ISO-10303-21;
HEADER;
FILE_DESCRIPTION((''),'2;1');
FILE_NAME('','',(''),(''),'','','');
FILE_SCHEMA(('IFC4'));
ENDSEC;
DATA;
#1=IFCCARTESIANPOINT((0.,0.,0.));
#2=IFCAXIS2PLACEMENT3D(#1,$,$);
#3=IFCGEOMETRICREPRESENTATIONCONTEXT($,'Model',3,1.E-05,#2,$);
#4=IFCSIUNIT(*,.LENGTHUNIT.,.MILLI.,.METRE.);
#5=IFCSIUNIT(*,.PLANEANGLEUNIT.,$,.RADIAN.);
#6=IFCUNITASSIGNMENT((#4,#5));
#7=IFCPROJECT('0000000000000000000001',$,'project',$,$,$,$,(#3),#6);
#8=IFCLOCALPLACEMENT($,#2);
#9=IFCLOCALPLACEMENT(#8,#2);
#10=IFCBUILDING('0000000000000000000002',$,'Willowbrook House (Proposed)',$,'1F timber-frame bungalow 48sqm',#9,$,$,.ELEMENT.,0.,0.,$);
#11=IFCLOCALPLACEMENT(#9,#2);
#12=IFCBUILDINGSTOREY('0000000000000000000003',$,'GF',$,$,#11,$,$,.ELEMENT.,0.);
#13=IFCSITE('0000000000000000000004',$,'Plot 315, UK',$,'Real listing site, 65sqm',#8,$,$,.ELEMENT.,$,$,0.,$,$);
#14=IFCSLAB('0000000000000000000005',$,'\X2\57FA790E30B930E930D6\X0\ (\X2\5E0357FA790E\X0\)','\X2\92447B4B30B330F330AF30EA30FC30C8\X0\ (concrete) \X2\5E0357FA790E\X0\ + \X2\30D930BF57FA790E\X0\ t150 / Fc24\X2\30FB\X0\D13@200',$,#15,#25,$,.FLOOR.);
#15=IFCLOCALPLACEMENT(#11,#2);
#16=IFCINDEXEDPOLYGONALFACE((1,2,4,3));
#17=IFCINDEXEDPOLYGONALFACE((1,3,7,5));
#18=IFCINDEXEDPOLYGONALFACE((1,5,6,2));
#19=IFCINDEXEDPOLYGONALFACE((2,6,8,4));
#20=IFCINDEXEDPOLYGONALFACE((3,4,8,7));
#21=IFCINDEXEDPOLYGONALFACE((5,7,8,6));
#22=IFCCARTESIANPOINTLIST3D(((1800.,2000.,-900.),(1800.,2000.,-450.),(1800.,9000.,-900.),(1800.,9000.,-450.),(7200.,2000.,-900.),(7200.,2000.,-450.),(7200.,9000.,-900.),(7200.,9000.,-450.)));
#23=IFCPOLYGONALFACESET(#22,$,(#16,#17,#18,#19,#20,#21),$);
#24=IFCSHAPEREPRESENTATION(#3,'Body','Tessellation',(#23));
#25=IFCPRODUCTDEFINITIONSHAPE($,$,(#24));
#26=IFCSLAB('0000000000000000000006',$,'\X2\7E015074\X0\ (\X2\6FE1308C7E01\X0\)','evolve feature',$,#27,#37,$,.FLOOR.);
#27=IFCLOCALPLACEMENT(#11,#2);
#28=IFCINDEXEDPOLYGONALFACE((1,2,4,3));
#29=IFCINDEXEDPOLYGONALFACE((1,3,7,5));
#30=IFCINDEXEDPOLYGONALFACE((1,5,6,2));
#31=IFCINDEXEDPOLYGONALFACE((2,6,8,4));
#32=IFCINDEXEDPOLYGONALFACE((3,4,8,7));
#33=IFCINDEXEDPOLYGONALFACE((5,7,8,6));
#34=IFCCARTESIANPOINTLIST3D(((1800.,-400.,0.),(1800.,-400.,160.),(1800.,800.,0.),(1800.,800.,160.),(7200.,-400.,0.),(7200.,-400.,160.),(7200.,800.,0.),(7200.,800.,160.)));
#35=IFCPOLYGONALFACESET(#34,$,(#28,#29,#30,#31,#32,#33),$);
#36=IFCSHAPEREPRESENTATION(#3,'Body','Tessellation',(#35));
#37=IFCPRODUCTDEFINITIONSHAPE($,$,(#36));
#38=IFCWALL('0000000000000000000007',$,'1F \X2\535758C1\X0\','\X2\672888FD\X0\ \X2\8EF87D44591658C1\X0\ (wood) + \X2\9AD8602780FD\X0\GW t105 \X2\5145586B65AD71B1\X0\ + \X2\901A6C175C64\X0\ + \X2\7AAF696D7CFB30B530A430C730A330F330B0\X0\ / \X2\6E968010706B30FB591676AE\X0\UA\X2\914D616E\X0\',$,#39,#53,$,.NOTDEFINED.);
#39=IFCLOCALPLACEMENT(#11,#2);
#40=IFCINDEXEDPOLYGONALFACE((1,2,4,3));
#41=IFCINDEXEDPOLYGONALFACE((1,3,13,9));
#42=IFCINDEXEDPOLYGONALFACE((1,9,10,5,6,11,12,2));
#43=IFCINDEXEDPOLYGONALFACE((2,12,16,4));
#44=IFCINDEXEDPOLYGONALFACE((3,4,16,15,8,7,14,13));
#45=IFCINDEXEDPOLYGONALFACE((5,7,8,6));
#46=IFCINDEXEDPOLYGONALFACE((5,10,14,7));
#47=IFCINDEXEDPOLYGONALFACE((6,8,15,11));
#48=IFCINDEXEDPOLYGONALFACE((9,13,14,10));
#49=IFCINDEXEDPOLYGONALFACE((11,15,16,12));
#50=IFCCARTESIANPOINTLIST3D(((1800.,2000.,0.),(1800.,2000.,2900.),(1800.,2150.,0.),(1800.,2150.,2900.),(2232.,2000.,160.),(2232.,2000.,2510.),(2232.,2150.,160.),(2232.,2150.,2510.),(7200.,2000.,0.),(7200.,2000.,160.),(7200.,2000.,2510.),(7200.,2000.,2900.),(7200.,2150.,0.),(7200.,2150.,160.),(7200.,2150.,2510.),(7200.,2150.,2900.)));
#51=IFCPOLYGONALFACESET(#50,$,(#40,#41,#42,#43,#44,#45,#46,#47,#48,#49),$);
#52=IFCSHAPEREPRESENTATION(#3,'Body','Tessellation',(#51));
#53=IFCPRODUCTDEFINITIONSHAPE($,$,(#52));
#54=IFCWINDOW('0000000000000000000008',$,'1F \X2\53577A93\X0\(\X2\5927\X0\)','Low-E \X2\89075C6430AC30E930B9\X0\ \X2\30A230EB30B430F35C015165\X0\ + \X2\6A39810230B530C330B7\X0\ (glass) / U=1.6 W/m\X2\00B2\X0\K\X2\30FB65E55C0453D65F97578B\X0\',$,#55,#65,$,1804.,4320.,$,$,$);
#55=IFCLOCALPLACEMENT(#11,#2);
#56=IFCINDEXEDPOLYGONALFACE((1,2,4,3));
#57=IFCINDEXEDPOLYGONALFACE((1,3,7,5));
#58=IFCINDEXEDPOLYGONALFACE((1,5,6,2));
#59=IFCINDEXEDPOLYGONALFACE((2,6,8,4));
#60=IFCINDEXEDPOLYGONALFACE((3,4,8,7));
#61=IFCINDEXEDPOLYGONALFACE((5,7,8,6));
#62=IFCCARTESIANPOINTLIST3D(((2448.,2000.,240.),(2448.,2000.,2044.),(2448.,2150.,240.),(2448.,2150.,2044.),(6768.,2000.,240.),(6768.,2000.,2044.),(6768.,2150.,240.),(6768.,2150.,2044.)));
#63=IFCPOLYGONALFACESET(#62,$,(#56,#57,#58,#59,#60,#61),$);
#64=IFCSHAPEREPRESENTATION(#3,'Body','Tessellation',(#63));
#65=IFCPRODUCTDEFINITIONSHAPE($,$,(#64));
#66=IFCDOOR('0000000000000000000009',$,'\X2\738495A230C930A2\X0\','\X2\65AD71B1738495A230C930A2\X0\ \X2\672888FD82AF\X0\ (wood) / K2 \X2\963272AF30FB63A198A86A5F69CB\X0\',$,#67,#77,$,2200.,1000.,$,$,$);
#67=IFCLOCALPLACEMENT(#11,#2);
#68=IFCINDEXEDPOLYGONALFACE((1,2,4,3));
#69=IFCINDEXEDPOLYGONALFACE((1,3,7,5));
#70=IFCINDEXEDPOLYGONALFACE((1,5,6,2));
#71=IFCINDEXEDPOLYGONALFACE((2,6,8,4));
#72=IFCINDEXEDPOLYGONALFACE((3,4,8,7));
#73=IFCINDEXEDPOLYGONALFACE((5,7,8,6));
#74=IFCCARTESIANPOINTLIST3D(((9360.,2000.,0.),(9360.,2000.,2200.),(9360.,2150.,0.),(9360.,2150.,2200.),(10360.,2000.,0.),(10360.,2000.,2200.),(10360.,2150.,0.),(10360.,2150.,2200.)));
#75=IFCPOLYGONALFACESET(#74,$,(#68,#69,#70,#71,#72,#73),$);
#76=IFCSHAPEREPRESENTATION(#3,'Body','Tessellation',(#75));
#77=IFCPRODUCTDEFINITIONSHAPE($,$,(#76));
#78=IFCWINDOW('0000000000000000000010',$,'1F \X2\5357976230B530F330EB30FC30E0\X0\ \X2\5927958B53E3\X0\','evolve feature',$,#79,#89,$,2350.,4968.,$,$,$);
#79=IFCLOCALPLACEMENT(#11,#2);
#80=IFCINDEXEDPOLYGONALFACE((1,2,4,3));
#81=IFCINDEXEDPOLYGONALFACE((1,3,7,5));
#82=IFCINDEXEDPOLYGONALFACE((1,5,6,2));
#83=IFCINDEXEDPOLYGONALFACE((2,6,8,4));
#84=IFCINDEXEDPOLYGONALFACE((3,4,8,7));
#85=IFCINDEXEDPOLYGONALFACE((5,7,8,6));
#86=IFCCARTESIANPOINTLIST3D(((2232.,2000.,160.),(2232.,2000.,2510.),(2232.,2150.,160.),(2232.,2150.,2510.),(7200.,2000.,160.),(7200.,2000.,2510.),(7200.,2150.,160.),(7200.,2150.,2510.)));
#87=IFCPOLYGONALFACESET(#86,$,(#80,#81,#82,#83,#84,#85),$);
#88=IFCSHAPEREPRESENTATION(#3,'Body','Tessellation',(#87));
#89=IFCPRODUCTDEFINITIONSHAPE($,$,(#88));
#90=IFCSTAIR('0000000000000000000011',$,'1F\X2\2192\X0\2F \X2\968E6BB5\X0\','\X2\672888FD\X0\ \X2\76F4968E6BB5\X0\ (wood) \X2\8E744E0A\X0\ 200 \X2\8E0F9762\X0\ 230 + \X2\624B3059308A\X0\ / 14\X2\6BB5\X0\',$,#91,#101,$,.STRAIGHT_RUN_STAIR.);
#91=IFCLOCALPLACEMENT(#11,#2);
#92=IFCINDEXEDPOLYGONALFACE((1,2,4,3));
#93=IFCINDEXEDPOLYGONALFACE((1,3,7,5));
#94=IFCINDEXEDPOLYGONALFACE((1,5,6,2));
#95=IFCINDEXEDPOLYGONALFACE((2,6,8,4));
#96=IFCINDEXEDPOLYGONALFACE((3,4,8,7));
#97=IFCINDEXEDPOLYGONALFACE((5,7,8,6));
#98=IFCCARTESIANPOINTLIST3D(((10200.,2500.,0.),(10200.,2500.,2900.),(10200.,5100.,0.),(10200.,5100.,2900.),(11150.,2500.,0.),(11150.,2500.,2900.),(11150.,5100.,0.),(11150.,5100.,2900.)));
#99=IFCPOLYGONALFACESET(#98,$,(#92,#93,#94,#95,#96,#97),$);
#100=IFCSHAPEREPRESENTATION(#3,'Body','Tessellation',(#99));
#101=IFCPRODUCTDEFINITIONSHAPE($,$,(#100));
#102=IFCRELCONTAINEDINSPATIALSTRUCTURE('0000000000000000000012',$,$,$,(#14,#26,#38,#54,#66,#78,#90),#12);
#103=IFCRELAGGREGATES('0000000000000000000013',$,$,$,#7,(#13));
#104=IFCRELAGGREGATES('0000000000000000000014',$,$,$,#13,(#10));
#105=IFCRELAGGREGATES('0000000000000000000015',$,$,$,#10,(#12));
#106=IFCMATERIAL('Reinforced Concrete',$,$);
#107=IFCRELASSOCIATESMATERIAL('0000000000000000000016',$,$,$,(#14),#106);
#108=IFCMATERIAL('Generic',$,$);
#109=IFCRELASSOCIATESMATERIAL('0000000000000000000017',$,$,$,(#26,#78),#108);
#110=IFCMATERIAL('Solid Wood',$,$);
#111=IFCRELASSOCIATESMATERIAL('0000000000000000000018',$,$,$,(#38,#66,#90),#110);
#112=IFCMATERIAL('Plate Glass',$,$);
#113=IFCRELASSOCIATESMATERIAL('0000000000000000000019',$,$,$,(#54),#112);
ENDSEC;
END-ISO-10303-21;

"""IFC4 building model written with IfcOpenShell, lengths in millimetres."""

from ifc_helpers import new_model, si_unit, frame, frame_2d, origin, place, context, project, spatial, rectangle, extrude, material, element, fill, save


model = new_model("IFC4")

# Units and contexts
model_context = context("Model", 3, precision=1e-05, world=origin())
ifc_project = project(units=[si_unit("LENGTHUNIT", "METRE", prefix="MILLI"), si_unit("PLANEANGLEUNIT", "RADIAN")], contexts=[model_context])

# Site, building, storey
site_placement = place(None, origin())
site = spatial("IfcSite", under=ifc_project, at=site_placement, Name="Plot 315, UK", ObjectType="Real listing site, 65sqm", CompositionType="ELEMENT", RefElevation=0.0)
building_placement = place(site_placement, origin())
building = spatial("IfcBuilding", under=site, at=building_placement, Name="Willowbrook House (Proposed)", ObjectType="1F timber-frame bungalow 48sqm", CompositionType="ELEMENT", ElevationOfRefHeight=0.0, ElevationOfTerrain=0.0)
storey_placement = place(building_placement, origin())
storey = spatial("IfcBuildingStorey", under=building, at=storey_placement, Name="GF", CompositionType="ELEMENT", Elevation=0.0)

# Slabs
ifc_material_1 = material(Name="Reinforced Concrete")
slab_1_placement = place(storey_placement, frame((900.0, 1000.0, -450.0)))
element("IfcSlab", 1, at=slab_1_placement, inside=storey, material=ifc_material_1, Name="基礎スラブ (布基礎)", Description="鉄筋コンクリート (concrete) 布基礎 + ベタ基礎 t150 / Fc24・D13@200", PredefinedType="FLOOR", context=model_context, shape_type="SweptSolid", body=[
    extrude(rectangle(XDim=5400.0, YDim=7000.0, at=frame_2d((2700.0, 3500.0))), frame((900.0, 1000.0, -450.0)), (0.0, 0.0, 1.0), 450.0),
])
ifc_material_2 = material(Name="Solid Wood")
ifc_material_3 = material(Name="Generic")
slab_2_placement = place(storey_placement, frame((900.0, -200.0, 0.0)))
element("IfcSlab", 2, at=slab_2_placement, inside=storey, material=ifc_material_3, Name="縁側 (濡れ縁)", Description="evolve feature", PredefinedType="FLOOR", context=model_context, shape_type="SweptSolid", body=[
    extrude(rectangle(XDim=5400.0, YDim=1200.0, at=frame_2d((2700.0, 600.0))), frame((900.0, -200.0, 0.0)), (0.0, 0.0, 1.0), 160.0),
])

# Wall, openings, windows, door
wall_1_placement = place(storey_placement, frame((900.0, 1000.0, 0.0)))
wall_1 = element("IfcWall", 3, at=wall_1_placement, inside=storey, material=ifc_material_2, Name="1F 南壁", Description="木製 軸組外壁 (wood) + 高性能GW t105 充填断熱 + 通気層 + 窯業系サイディング / 準耐火・外皮UA配慮", PredefinedType="NOTDEFINED", context=model_context, shape_type="SweptSolid", body=[
    extrude(rectangle(XDim=5400.0, YDim=150.0, at=frame_2d((2700.0, 75.0))), frame((900.0, 1000.0, 0.0)), (0.0, 0.0, 1.0), 2900.0),
])
opening_1_placement = place(storey_placement, frame((1224.0, 1000.0, 120.0)))
opening_1 = element("IfcOpeningElement", 4, at=opening_1_placement, cuts=wall_1, PredefinedType="NOTDEFINED", context=model_context, shape_type="SweptSolid", body=[
    extrude(rectangle(XDim=4320.0, YDim=150.0, at=frame_2d((2160.0, 75.0))), frame((1224.0, 1000.0, 120.0)), (0.0, 0.0, 1.0), 1804.0),
])
opening_2_placement = place(storey_placement, frame((4680.0, 1000.0, 0.0)))
opening_2 = element("IfcOpeningElement", 5, at=opening_2_placement, cuts=wall_1, PredefinedType="NOTDEFINED", context=model_context, shape_type="SweptSolid", body=[
    extrude(rectangle(XDim=1000.0, YDim=150.0, at=frame_2d((500.0, 75.0))), frame((4680.0, 1000.0, 0.0)), (0.0, 0.0, 1.0), 2200.0),
])
opening_3_placement = place(storey_placement, frame((1116.0, 1000.0, 80.0)))
opening_3 = element("IfcOpeningElement", 6, at=opening_3_placement, cuts=wall_1, PredefinedType="NOTDEFINED", context=model_context, shape_type="SweptSolid", body=[
    extrude(rectangle(XDim=4968.0, YDim=150.0, at=frame_2d((2484.0, 75.0))), frame((1116.0, 1000.0, 80.0)), (0.0, 0.0, 1.0), 2350.0),
])
ifc_material_4 = material(Name="Plate Glass")
window_1_placement = place(storey_placement, frame((1224.0, 1000.0, 120.0)))
window_1 = element("IfcWindow", 7, at=window_1_placement, inside=storey, material=ifc_material_4, Name="1F 南窓(大)", Description="Low-E 複層ガラス アルゴン封入 + 樹脂サッシ (glass) / U=1.6 W/m²K・日射取得型", OverallHeight=1804.0, OverallWidth=4320.0, context=model_context, shape_type="SweptSolid", body=[
    extrude(rectangle(XDim=4320.0, YDim=150.0, at=frame_2d((2160.0, 75.0))), frame((1224.0, 1000.0, 120.0)), (0.0, 0.0, 1.0), 1804.0),
])
fill(opening_1, window_1)
door_placement = place(storey_placement, frame((4680.0, 1000.0, 0.0)))
door = element("IfcDoor", 8, at=door_placement, inside=storey, material=ifc_material_2, Name="玄関ドア", Description="断熱玄関ドア 木製芯 (wood) / K2 防犯・採風機構", OverallHeight=2200.0, OverallWidth=1000.0, context=model_context, shape_type="SweptSolid", body=[
    extrude(rectangle(XDim=1000.0, YDim=150.0, at=frame_2d((500.0, 75.0))), frame((4680.0, 1000.0, 0.0)), (0.0, 0.0, 1.0), 2200.0),
])
fill(opening_2, door)
window_2_placement = place(storey_placement, frame((1116.0, 1000.0, 80.0)))
window_2 = element("IfcWindow", 9, at=window_2_placement, inside=storey, material=ifc_material_3, Name="1F 南面サンルーム 大開口", Description="evolve feature", OverallHeight=2350.0, OverallWidth=4968.0, context=model_context, shape_type="SweptSolid", body=[
    extrude(rectangle(XDim=4968.0, YDim=150.0, at=frame_2d((2484.0, 75.0))), frame((1116.0, 1000.0, 80.0)), (0.0, 0.0, 1.0), 2350.0),
])
fill(opening_3, window_2)

# Stair
stair_placement = place(storey_placement, frame((5100.0, 1250.0, 0.0)))
element("IfcStair", 10, at=stair_placement, inside=storey, material=ifc_material_2, Name="1F→2F 階段", Description="木製 直階段 (wood) 蹴上 200 踏面 230 + 手すり / 14段", PredefinedType="STRAIGHT_RUN_STAIR", context=model_context, shape_type="SweptSolid", body=[
    extrude(rectangle(XDim=950.0, YDim=2600.0, at=frame_2d((475.0, 1300.0))), frame((5100.0, 1250.0, 0.0)), (0.0, 0.0, 1.0), 2900.0),
])

save(model, "model.ifc")
